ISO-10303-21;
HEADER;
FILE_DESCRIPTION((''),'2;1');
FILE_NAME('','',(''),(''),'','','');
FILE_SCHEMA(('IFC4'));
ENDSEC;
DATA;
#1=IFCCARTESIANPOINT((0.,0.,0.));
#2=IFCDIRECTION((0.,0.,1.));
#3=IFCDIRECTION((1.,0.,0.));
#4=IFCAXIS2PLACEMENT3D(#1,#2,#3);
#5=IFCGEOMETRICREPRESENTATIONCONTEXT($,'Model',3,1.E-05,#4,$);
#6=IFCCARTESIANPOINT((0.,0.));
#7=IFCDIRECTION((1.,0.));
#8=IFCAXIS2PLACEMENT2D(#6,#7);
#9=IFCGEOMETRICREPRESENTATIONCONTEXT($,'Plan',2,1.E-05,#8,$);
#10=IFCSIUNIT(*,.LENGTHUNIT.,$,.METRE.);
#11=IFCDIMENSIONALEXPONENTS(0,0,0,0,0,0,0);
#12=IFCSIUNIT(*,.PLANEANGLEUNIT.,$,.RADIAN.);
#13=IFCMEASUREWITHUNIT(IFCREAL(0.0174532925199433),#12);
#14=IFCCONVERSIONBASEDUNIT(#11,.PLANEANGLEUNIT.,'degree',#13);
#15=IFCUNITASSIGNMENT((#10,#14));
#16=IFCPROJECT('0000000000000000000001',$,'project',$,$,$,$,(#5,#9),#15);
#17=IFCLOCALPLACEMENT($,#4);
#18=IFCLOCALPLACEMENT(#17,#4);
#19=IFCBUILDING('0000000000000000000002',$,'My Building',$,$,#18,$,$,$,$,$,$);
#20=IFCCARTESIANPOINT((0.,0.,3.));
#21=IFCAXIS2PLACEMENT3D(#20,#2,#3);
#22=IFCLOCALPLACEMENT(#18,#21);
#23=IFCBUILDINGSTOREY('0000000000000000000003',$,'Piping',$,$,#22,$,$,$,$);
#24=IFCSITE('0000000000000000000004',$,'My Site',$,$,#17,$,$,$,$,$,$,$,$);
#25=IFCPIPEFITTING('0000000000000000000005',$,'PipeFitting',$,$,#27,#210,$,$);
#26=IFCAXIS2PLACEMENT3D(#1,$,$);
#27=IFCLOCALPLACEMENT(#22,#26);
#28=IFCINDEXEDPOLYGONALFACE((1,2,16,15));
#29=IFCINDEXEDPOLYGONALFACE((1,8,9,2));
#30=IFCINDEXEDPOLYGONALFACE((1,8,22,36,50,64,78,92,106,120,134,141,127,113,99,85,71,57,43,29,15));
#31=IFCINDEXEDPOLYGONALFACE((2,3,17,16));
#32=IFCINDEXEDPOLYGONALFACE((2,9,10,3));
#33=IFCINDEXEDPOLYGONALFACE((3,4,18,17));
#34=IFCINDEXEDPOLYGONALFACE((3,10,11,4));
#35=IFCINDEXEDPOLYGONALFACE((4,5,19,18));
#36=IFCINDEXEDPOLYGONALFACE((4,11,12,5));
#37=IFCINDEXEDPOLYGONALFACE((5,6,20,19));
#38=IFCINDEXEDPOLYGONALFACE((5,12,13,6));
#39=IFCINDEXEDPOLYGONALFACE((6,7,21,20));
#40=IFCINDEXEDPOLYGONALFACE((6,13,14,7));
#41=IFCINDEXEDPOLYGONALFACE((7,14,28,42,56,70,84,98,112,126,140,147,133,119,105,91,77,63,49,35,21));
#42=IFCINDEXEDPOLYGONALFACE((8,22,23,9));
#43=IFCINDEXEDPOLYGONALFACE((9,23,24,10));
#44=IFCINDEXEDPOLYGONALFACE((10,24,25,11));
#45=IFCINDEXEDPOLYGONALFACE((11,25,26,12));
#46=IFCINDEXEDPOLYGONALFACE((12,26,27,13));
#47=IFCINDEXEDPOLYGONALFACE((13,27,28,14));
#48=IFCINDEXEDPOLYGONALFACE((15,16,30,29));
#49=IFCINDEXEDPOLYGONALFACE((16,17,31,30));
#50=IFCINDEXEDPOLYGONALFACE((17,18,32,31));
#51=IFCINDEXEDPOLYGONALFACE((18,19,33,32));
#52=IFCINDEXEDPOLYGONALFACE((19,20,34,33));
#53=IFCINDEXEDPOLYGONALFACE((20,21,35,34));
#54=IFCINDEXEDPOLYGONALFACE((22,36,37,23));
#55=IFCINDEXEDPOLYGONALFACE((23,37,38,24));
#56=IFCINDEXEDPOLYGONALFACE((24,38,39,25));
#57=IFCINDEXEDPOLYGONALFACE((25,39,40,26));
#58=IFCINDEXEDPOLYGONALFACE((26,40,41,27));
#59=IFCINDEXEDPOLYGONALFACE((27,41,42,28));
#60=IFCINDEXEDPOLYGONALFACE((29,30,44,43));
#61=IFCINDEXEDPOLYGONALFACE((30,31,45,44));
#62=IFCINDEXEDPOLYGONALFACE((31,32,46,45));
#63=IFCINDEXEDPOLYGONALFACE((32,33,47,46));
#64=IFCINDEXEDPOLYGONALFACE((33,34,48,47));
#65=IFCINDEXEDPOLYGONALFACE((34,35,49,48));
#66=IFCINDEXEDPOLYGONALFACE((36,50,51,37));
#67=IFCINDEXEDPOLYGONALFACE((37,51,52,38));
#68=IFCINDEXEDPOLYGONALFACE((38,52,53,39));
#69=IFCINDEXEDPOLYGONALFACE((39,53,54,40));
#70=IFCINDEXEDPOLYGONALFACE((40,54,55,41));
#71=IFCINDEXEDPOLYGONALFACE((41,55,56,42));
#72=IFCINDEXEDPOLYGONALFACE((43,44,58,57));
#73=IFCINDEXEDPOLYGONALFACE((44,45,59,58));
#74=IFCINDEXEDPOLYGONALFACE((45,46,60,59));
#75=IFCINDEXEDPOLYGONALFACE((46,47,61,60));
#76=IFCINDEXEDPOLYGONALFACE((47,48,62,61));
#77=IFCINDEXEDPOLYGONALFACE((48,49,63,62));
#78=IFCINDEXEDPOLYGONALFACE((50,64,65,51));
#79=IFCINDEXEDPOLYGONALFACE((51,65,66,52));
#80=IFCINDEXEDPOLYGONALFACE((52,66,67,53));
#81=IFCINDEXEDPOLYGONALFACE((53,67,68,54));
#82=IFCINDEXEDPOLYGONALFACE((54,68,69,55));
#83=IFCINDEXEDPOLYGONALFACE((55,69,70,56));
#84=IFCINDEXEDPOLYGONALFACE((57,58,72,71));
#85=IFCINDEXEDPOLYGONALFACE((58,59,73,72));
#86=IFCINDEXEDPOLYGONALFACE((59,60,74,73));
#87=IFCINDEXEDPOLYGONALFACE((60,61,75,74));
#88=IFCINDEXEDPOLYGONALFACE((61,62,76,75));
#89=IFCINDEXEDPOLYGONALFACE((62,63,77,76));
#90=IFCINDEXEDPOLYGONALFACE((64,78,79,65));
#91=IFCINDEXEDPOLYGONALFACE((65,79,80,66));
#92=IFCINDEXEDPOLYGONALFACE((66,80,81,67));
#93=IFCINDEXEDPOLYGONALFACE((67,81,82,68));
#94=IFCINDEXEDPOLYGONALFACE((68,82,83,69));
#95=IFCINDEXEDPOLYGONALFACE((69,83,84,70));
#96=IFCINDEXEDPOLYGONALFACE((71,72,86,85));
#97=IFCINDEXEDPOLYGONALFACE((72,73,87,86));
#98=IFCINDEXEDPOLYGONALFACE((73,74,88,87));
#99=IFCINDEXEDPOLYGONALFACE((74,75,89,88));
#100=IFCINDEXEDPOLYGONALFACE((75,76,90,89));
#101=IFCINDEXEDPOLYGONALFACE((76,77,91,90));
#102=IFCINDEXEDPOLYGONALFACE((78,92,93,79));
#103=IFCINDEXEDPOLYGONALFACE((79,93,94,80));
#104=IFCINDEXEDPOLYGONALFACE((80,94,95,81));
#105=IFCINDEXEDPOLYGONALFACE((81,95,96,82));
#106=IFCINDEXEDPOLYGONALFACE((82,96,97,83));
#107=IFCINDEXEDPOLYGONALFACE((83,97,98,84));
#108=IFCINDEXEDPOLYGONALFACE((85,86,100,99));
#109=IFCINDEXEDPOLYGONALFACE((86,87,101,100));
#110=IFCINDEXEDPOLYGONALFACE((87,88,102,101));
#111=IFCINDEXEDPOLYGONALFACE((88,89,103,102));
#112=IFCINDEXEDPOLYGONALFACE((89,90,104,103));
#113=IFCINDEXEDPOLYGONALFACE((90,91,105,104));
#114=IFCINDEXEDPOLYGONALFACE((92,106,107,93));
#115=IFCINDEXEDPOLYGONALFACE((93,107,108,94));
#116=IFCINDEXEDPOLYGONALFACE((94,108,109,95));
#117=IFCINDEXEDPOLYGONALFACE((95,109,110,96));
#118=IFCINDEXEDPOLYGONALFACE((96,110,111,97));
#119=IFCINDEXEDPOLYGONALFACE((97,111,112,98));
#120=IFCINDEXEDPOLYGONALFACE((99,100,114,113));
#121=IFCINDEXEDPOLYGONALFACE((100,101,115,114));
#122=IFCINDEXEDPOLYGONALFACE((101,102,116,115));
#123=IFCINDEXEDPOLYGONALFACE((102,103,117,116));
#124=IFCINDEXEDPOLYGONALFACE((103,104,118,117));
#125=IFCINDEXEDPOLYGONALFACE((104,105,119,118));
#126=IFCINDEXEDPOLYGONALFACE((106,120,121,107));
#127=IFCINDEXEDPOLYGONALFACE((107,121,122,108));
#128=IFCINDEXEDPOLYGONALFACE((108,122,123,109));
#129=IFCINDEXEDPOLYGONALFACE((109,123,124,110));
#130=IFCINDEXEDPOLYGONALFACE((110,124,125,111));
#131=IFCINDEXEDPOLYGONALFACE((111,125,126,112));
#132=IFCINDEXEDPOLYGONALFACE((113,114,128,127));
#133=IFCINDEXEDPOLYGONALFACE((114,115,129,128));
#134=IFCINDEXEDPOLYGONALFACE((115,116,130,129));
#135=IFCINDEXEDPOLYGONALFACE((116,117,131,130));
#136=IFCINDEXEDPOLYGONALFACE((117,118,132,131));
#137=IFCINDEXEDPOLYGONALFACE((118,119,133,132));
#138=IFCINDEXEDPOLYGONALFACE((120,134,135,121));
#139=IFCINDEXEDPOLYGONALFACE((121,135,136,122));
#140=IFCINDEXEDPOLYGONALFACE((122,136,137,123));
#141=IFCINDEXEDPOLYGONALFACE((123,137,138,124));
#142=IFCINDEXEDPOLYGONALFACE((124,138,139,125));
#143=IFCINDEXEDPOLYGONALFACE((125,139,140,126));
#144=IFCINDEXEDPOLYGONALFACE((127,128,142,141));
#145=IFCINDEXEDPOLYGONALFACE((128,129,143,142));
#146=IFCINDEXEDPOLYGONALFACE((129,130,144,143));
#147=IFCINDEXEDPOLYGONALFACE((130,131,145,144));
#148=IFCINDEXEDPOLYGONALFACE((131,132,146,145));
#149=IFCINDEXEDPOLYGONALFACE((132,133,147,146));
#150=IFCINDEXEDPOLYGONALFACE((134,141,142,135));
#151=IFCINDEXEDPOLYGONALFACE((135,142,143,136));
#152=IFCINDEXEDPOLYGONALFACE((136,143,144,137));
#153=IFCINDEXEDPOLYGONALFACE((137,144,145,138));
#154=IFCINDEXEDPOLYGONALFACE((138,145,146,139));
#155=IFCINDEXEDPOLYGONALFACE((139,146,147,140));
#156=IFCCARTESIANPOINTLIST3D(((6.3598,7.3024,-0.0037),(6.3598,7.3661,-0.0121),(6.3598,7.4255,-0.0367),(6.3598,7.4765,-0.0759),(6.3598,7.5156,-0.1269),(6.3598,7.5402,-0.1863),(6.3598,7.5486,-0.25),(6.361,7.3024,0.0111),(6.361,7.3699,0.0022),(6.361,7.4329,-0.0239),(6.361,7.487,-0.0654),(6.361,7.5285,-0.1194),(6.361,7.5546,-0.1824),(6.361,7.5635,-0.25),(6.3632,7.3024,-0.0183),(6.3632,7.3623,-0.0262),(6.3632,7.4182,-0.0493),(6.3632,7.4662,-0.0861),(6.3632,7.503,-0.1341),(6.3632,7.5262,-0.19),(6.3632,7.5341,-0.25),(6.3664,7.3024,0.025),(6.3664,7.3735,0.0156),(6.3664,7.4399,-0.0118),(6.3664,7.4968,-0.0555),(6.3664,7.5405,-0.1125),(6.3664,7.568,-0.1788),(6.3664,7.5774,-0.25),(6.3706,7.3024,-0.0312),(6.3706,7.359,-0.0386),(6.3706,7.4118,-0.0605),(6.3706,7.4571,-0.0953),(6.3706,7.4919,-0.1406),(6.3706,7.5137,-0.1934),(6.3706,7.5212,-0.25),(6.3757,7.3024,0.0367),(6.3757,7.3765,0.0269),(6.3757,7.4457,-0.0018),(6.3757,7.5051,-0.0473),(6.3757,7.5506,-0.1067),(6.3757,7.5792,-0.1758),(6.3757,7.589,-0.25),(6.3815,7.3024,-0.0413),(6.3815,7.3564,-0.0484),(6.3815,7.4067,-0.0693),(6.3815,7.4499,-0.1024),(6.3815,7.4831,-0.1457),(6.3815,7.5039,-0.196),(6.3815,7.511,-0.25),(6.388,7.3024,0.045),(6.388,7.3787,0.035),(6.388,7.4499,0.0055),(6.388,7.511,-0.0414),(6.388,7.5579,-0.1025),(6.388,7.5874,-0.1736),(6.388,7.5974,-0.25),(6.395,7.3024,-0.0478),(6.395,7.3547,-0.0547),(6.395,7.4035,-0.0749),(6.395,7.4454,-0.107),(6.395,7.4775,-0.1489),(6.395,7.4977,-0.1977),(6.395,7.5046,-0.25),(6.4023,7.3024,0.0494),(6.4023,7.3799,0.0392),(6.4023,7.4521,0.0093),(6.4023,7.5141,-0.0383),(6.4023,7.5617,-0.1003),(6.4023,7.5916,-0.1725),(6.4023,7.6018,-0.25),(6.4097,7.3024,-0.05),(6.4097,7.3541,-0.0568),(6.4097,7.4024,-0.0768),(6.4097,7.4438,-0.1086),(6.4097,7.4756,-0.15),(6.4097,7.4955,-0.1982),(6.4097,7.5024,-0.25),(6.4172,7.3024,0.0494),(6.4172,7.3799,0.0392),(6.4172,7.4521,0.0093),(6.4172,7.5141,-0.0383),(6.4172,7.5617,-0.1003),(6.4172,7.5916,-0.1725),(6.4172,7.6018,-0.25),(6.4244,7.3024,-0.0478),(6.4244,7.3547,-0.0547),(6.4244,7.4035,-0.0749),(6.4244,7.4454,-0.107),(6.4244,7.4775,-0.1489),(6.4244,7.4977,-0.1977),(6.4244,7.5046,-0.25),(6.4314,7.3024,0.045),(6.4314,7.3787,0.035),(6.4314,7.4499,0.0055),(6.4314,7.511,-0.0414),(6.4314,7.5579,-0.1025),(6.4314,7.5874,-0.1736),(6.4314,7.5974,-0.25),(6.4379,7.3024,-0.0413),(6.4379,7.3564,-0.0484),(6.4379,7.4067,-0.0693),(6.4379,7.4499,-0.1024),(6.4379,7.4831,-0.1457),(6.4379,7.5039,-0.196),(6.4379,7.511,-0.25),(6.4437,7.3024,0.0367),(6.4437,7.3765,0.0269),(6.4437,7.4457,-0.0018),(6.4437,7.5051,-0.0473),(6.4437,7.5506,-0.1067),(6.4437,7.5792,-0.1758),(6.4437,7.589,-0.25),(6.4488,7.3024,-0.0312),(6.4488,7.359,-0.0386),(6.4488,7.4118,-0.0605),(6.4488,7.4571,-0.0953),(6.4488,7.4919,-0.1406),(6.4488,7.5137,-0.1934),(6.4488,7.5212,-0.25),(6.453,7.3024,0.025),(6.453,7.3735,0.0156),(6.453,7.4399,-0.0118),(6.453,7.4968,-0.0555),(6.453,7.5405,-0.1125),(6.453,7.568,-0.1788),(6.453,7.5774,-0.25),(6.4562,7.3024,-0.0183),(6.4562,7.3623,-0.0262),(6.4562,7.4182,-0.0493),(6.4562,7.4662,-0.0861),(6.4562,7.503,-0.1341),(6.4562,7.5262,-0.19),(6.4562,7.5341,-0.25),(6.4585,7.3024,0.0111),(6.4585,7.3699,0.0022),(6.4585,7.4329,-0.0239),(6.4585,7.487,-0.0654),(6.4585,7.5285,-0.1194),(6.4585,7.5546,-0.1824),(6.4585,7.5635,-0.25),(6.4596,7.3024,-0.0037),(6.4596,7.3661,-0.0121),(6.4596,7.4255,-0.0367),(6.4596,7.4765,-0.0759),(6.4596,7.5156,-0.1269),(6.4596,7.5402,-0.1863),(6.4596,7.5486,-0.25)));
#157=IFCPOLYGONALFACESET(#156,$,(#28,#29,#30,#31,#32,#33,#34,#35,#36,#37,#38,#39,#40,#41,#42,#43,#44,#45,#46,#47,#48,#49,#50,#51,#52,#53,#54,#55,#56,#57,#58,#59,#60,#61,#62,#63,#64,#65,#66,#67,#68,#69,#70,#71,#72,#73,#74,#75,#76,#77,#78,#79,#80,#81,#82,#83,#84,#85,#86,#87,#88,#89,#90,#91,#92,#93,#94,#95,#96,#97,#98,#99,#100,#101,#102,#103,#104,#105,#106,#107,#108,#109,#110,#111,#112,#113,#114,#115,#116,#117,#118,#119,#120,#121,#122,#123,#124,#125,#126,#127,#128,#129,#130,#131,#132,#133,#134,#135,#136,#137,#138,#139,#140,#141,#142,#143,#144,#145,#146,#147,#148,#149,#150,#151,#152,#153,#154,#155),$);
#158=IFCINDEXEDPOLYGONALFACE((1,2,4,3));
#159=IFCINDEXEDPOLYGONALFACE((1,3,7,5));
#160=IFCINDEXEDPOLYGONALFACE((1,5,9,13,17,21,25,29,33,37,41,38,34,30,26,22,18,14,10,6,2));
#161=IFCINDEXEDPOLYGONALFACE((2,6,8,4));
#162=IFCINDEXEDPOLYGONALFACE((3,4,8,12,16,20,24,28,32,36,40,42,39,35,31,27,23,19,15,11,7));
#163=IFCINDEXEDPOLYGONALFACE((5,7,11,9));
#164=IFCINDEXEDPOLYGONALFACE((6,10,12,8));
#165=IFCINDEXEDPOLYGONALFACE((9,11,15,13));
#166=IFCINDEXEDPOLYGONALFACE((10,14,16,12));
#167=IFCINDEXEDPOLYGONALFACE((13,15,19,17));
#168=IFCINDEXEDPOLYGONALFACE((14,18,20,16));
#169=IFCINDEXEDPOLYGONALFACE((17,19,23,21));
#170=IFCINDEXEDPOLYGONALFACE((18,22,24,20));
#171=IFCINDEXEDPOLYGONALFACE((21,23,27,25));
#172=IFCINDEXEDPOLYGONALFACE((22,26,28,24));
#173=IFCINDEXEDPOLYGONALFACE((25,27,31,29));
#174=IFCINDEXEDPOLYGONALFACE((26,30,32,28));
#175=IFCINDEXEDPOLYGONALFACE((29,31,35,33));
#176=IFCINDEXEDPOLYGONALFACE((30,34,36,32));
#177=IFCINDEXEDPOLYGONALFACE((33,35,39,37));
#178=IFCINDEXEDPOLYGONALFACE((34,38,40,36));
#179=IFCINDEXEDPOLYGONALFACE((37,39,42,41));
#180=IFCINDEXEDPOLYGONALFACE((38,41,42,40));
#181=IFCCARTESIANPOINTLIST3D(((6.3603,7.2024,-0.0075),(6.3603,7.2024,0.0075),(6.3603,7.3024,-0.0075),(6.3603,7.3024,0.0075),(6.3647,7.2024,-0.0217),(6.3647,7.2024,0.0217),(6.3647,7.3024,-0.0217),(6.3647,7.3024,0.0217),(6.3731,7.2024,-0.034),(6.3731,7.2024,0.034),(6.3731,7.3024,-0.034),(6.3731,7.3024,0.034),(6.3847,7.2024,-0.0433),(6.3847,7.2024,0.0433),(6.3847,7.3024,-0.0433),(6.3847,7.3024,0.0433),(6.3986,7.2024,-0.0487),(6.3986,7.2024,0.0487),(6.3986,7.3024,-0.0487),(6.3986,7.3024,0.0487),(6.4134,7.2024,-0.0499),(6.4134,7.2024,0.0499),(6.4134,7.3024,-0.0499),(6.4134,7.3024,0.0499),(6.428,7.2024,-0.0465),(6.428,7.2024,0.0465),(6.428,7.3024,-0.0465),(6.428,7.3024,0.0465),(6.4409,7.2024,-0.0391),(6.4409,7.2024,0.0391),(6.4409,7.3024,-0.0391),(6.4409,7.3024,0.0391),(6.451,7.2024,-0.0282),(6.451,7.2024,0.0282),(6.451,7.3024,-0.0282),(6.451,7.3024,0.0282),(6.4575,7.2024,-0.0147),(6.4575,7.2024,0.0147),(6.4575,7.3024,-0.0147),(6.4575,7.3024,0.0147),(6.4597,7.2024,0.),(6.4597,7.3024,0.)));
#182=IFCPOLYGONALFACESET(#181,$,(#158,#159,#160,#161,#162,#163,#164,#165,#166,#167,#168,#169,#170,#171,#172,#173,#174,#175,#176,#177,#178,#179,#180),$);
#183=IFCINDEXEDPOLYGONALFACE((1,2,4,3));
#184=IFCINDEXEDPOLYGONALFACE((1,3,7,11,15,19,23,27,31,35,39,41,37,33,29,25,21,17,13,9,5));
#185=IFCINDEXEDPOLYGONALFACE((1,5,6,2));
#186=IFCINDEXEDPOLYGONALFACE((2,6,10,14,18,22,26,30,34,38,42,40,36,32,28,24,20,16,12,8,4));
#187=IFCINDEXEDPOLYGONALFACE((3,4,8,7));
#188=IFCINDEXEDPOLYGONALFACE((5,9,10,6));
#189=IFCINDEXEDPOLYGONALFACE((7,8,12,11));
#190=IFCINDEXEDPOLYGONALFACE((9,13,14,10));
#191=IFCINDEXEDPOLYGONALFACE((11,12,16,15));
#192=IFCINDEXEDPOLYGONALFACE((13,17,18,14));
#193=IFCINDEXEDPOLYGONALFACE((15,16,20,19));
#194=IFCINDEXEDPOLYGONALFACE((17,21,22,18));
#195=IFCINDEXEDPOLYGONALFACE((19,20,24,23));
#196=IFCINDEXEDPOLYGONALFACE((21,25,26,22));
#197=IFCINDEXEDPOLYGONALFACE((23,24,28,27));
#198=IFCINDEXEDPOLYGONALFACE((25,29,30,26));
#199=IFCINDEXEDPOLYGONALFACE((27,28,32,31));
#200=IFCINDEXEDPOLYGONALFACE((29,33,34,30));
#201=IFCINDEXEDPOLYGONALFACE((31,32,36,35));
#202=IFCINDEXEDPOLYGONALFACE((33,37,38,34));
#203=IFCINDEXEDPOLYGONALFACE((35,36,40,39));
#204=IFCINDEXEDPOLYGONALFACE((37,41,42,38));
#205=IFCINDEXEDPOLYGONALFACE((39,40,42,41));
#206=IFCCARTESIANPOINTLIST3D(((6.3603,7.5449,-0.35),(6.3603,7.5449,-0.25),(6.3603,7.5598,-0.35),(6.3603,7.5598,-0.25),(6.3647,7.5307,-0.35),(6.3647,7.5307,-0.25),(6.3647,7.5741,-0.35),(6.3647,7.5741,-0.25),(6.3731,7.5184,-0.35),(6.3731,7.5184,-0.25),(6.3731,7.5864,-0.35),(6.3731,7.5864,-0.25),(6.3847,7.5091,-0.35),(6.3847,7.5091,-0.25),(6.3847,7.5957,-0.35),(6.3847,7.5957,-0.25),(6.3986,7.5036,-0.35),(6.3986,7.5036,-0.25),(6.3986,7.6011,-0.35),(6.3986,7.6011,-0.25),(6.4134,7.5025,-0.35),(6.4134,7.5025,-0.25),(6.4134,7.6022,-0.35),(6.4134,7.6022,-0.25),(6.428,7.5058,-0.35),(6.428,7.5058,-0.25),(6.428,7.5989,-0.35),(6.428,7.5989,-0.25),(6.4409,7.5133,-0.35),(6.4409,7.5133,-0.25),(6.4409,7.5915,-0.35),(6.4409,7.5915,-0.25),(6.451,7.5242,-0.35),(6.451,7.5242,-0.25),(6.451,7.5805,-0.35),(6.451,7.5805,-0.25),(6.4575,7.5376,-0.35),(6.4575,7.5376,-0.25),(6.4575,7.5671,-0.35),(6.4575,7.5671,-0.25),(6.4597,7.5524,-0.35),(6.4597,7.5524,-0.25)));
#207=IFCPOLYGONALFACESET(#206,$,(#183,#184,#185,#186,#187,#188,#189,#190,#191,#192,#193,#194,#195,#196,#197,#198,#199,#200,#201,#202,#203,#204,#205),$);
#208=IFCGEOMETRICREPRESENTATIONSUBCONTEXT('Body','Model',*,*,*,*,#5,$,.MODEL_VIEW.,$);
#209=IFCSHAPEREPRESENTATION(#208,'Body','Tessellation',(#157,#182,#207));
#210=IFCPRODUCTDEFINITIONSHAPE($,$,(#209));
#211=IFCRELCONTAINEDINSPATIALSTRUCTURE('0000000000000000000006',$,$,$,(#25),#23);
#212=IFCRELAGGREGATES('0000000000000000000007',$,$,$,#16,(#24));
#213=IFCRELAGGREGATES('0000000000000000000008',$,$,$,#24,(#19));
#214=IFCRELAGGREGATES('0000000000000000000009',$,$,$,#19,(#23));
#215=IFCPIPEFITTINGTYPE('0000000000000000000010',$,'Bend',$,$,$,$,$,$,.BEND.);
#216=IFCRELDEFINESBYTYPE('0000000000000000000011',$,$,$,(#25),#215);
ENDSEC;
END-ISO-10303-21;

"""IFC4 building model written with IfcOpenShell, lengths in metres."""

from ifc_helpers import new_model, entity, si_unit, converted_unit, frame, origin_with_axes, origin_2d_with_axis, place, context, subcontext, project, spatial, circle, extrude, source, transform, mapped, type_object, type_shapes, element, save


model = new_model("IFC4")

# Units and contexts
model_context = context("Model", 3, precision=1e-05, world=origin_with_axes())
plan_context = context("Plan", 2, precision=1e-05, world=origin_2d_with_axis())
body_context = subcontext(model_context, "Body", "Model", "MODEL_VIEW")
ifc_project = project(units=[si_unit("LENGTHUNIT", "METRE"), converted_unit("PLANEANGLEUNIT", "degree", entity("IfcReal", 0.0174532925199433), si_unit("PLANEANGLEUNIT", "RADIAN"), dimensions=[0, 0, 0, 0, 0, 0, 0])], contexts=[model_context, plan_context])

# Site, building, storey
site_placement = place(None, origin_with_axes())
site = spatial("IfcSite", under=ifc_project, at=site_placement, Name="My Site")
building_placement = place(site_placement, origin_with_axes())
building = spatial("IfcBuilding", under=site, at=building_placement, Name="My Building")
storey_placement = place(building_placement, frame((0.0, 0.0, 3.0), z_axis=(0.0, 0.0, 1.0), x_axis=(1.0, 0.0, 0.0)))
storey = spatial("IfcBuildingStorey", under=building, at=storey_placement, Name="Piping")

# Shared definitions
pipe_fitting_type_1 = type_object("IfcPipeFittingType", Name="Bend", PredefinedType="BEND")
shared_shape = source(origin_with_axes(), body_context, "Body", "SolidModel", [
    entity("IfcSweptDiskSolid", entity("IfcIndexedPolyCurve", entity("IfcCartesianPointList3D", [[0.0, 0.0, -0.1], [0.0, -0.0732, -0.2768], [0.0, -0.25, -0.35]]), [entity("IfcArcIndex", [1, 2, 3])]), 0.05),
    extrude(circle(Radius=0.05), origin_with_axes(), (0.0, 0.0, -1.0), 0.1),
    extrude(circle(Radius=0.05), frame((0.0, -0.25, -0.35), z_axis=(0.0, -1.0, 0.0), x_axis=(1.0, 0.0, 0.0)), (0.0, 0.0, 1.0), 0.1),
])
type_shapes(pipe_fitting_type_1, [shared_shape])

# Pipe fitting
for number, where, z_axis, x_axis, name in (
    (1, (6.4097, 7.2024, 0.0), (0.0, -1.0, 0.0), (1.0, 0.0, 0.0), "PipeFitting"),
):
    element("IfcPipeFitting", number, at=place(storey_placement, frame(where, z_axis=z_axis, x_axis=x_axis)), inside=storey, type_object=pipe_fitting_type_1, Name=name, context=body_context, shape_type="MappedRepresentation", body=[
        mapped(shared_shape, transform((0.0, 0.0, 0.0), x_axis=(1.0, 0.0, 0.0), y_axis=(0.0, 1.0, 0.0), z_axis=(0.0, 0.0, 1.0), scale=1.0)),
    ])

save(model, "model.ifc")
